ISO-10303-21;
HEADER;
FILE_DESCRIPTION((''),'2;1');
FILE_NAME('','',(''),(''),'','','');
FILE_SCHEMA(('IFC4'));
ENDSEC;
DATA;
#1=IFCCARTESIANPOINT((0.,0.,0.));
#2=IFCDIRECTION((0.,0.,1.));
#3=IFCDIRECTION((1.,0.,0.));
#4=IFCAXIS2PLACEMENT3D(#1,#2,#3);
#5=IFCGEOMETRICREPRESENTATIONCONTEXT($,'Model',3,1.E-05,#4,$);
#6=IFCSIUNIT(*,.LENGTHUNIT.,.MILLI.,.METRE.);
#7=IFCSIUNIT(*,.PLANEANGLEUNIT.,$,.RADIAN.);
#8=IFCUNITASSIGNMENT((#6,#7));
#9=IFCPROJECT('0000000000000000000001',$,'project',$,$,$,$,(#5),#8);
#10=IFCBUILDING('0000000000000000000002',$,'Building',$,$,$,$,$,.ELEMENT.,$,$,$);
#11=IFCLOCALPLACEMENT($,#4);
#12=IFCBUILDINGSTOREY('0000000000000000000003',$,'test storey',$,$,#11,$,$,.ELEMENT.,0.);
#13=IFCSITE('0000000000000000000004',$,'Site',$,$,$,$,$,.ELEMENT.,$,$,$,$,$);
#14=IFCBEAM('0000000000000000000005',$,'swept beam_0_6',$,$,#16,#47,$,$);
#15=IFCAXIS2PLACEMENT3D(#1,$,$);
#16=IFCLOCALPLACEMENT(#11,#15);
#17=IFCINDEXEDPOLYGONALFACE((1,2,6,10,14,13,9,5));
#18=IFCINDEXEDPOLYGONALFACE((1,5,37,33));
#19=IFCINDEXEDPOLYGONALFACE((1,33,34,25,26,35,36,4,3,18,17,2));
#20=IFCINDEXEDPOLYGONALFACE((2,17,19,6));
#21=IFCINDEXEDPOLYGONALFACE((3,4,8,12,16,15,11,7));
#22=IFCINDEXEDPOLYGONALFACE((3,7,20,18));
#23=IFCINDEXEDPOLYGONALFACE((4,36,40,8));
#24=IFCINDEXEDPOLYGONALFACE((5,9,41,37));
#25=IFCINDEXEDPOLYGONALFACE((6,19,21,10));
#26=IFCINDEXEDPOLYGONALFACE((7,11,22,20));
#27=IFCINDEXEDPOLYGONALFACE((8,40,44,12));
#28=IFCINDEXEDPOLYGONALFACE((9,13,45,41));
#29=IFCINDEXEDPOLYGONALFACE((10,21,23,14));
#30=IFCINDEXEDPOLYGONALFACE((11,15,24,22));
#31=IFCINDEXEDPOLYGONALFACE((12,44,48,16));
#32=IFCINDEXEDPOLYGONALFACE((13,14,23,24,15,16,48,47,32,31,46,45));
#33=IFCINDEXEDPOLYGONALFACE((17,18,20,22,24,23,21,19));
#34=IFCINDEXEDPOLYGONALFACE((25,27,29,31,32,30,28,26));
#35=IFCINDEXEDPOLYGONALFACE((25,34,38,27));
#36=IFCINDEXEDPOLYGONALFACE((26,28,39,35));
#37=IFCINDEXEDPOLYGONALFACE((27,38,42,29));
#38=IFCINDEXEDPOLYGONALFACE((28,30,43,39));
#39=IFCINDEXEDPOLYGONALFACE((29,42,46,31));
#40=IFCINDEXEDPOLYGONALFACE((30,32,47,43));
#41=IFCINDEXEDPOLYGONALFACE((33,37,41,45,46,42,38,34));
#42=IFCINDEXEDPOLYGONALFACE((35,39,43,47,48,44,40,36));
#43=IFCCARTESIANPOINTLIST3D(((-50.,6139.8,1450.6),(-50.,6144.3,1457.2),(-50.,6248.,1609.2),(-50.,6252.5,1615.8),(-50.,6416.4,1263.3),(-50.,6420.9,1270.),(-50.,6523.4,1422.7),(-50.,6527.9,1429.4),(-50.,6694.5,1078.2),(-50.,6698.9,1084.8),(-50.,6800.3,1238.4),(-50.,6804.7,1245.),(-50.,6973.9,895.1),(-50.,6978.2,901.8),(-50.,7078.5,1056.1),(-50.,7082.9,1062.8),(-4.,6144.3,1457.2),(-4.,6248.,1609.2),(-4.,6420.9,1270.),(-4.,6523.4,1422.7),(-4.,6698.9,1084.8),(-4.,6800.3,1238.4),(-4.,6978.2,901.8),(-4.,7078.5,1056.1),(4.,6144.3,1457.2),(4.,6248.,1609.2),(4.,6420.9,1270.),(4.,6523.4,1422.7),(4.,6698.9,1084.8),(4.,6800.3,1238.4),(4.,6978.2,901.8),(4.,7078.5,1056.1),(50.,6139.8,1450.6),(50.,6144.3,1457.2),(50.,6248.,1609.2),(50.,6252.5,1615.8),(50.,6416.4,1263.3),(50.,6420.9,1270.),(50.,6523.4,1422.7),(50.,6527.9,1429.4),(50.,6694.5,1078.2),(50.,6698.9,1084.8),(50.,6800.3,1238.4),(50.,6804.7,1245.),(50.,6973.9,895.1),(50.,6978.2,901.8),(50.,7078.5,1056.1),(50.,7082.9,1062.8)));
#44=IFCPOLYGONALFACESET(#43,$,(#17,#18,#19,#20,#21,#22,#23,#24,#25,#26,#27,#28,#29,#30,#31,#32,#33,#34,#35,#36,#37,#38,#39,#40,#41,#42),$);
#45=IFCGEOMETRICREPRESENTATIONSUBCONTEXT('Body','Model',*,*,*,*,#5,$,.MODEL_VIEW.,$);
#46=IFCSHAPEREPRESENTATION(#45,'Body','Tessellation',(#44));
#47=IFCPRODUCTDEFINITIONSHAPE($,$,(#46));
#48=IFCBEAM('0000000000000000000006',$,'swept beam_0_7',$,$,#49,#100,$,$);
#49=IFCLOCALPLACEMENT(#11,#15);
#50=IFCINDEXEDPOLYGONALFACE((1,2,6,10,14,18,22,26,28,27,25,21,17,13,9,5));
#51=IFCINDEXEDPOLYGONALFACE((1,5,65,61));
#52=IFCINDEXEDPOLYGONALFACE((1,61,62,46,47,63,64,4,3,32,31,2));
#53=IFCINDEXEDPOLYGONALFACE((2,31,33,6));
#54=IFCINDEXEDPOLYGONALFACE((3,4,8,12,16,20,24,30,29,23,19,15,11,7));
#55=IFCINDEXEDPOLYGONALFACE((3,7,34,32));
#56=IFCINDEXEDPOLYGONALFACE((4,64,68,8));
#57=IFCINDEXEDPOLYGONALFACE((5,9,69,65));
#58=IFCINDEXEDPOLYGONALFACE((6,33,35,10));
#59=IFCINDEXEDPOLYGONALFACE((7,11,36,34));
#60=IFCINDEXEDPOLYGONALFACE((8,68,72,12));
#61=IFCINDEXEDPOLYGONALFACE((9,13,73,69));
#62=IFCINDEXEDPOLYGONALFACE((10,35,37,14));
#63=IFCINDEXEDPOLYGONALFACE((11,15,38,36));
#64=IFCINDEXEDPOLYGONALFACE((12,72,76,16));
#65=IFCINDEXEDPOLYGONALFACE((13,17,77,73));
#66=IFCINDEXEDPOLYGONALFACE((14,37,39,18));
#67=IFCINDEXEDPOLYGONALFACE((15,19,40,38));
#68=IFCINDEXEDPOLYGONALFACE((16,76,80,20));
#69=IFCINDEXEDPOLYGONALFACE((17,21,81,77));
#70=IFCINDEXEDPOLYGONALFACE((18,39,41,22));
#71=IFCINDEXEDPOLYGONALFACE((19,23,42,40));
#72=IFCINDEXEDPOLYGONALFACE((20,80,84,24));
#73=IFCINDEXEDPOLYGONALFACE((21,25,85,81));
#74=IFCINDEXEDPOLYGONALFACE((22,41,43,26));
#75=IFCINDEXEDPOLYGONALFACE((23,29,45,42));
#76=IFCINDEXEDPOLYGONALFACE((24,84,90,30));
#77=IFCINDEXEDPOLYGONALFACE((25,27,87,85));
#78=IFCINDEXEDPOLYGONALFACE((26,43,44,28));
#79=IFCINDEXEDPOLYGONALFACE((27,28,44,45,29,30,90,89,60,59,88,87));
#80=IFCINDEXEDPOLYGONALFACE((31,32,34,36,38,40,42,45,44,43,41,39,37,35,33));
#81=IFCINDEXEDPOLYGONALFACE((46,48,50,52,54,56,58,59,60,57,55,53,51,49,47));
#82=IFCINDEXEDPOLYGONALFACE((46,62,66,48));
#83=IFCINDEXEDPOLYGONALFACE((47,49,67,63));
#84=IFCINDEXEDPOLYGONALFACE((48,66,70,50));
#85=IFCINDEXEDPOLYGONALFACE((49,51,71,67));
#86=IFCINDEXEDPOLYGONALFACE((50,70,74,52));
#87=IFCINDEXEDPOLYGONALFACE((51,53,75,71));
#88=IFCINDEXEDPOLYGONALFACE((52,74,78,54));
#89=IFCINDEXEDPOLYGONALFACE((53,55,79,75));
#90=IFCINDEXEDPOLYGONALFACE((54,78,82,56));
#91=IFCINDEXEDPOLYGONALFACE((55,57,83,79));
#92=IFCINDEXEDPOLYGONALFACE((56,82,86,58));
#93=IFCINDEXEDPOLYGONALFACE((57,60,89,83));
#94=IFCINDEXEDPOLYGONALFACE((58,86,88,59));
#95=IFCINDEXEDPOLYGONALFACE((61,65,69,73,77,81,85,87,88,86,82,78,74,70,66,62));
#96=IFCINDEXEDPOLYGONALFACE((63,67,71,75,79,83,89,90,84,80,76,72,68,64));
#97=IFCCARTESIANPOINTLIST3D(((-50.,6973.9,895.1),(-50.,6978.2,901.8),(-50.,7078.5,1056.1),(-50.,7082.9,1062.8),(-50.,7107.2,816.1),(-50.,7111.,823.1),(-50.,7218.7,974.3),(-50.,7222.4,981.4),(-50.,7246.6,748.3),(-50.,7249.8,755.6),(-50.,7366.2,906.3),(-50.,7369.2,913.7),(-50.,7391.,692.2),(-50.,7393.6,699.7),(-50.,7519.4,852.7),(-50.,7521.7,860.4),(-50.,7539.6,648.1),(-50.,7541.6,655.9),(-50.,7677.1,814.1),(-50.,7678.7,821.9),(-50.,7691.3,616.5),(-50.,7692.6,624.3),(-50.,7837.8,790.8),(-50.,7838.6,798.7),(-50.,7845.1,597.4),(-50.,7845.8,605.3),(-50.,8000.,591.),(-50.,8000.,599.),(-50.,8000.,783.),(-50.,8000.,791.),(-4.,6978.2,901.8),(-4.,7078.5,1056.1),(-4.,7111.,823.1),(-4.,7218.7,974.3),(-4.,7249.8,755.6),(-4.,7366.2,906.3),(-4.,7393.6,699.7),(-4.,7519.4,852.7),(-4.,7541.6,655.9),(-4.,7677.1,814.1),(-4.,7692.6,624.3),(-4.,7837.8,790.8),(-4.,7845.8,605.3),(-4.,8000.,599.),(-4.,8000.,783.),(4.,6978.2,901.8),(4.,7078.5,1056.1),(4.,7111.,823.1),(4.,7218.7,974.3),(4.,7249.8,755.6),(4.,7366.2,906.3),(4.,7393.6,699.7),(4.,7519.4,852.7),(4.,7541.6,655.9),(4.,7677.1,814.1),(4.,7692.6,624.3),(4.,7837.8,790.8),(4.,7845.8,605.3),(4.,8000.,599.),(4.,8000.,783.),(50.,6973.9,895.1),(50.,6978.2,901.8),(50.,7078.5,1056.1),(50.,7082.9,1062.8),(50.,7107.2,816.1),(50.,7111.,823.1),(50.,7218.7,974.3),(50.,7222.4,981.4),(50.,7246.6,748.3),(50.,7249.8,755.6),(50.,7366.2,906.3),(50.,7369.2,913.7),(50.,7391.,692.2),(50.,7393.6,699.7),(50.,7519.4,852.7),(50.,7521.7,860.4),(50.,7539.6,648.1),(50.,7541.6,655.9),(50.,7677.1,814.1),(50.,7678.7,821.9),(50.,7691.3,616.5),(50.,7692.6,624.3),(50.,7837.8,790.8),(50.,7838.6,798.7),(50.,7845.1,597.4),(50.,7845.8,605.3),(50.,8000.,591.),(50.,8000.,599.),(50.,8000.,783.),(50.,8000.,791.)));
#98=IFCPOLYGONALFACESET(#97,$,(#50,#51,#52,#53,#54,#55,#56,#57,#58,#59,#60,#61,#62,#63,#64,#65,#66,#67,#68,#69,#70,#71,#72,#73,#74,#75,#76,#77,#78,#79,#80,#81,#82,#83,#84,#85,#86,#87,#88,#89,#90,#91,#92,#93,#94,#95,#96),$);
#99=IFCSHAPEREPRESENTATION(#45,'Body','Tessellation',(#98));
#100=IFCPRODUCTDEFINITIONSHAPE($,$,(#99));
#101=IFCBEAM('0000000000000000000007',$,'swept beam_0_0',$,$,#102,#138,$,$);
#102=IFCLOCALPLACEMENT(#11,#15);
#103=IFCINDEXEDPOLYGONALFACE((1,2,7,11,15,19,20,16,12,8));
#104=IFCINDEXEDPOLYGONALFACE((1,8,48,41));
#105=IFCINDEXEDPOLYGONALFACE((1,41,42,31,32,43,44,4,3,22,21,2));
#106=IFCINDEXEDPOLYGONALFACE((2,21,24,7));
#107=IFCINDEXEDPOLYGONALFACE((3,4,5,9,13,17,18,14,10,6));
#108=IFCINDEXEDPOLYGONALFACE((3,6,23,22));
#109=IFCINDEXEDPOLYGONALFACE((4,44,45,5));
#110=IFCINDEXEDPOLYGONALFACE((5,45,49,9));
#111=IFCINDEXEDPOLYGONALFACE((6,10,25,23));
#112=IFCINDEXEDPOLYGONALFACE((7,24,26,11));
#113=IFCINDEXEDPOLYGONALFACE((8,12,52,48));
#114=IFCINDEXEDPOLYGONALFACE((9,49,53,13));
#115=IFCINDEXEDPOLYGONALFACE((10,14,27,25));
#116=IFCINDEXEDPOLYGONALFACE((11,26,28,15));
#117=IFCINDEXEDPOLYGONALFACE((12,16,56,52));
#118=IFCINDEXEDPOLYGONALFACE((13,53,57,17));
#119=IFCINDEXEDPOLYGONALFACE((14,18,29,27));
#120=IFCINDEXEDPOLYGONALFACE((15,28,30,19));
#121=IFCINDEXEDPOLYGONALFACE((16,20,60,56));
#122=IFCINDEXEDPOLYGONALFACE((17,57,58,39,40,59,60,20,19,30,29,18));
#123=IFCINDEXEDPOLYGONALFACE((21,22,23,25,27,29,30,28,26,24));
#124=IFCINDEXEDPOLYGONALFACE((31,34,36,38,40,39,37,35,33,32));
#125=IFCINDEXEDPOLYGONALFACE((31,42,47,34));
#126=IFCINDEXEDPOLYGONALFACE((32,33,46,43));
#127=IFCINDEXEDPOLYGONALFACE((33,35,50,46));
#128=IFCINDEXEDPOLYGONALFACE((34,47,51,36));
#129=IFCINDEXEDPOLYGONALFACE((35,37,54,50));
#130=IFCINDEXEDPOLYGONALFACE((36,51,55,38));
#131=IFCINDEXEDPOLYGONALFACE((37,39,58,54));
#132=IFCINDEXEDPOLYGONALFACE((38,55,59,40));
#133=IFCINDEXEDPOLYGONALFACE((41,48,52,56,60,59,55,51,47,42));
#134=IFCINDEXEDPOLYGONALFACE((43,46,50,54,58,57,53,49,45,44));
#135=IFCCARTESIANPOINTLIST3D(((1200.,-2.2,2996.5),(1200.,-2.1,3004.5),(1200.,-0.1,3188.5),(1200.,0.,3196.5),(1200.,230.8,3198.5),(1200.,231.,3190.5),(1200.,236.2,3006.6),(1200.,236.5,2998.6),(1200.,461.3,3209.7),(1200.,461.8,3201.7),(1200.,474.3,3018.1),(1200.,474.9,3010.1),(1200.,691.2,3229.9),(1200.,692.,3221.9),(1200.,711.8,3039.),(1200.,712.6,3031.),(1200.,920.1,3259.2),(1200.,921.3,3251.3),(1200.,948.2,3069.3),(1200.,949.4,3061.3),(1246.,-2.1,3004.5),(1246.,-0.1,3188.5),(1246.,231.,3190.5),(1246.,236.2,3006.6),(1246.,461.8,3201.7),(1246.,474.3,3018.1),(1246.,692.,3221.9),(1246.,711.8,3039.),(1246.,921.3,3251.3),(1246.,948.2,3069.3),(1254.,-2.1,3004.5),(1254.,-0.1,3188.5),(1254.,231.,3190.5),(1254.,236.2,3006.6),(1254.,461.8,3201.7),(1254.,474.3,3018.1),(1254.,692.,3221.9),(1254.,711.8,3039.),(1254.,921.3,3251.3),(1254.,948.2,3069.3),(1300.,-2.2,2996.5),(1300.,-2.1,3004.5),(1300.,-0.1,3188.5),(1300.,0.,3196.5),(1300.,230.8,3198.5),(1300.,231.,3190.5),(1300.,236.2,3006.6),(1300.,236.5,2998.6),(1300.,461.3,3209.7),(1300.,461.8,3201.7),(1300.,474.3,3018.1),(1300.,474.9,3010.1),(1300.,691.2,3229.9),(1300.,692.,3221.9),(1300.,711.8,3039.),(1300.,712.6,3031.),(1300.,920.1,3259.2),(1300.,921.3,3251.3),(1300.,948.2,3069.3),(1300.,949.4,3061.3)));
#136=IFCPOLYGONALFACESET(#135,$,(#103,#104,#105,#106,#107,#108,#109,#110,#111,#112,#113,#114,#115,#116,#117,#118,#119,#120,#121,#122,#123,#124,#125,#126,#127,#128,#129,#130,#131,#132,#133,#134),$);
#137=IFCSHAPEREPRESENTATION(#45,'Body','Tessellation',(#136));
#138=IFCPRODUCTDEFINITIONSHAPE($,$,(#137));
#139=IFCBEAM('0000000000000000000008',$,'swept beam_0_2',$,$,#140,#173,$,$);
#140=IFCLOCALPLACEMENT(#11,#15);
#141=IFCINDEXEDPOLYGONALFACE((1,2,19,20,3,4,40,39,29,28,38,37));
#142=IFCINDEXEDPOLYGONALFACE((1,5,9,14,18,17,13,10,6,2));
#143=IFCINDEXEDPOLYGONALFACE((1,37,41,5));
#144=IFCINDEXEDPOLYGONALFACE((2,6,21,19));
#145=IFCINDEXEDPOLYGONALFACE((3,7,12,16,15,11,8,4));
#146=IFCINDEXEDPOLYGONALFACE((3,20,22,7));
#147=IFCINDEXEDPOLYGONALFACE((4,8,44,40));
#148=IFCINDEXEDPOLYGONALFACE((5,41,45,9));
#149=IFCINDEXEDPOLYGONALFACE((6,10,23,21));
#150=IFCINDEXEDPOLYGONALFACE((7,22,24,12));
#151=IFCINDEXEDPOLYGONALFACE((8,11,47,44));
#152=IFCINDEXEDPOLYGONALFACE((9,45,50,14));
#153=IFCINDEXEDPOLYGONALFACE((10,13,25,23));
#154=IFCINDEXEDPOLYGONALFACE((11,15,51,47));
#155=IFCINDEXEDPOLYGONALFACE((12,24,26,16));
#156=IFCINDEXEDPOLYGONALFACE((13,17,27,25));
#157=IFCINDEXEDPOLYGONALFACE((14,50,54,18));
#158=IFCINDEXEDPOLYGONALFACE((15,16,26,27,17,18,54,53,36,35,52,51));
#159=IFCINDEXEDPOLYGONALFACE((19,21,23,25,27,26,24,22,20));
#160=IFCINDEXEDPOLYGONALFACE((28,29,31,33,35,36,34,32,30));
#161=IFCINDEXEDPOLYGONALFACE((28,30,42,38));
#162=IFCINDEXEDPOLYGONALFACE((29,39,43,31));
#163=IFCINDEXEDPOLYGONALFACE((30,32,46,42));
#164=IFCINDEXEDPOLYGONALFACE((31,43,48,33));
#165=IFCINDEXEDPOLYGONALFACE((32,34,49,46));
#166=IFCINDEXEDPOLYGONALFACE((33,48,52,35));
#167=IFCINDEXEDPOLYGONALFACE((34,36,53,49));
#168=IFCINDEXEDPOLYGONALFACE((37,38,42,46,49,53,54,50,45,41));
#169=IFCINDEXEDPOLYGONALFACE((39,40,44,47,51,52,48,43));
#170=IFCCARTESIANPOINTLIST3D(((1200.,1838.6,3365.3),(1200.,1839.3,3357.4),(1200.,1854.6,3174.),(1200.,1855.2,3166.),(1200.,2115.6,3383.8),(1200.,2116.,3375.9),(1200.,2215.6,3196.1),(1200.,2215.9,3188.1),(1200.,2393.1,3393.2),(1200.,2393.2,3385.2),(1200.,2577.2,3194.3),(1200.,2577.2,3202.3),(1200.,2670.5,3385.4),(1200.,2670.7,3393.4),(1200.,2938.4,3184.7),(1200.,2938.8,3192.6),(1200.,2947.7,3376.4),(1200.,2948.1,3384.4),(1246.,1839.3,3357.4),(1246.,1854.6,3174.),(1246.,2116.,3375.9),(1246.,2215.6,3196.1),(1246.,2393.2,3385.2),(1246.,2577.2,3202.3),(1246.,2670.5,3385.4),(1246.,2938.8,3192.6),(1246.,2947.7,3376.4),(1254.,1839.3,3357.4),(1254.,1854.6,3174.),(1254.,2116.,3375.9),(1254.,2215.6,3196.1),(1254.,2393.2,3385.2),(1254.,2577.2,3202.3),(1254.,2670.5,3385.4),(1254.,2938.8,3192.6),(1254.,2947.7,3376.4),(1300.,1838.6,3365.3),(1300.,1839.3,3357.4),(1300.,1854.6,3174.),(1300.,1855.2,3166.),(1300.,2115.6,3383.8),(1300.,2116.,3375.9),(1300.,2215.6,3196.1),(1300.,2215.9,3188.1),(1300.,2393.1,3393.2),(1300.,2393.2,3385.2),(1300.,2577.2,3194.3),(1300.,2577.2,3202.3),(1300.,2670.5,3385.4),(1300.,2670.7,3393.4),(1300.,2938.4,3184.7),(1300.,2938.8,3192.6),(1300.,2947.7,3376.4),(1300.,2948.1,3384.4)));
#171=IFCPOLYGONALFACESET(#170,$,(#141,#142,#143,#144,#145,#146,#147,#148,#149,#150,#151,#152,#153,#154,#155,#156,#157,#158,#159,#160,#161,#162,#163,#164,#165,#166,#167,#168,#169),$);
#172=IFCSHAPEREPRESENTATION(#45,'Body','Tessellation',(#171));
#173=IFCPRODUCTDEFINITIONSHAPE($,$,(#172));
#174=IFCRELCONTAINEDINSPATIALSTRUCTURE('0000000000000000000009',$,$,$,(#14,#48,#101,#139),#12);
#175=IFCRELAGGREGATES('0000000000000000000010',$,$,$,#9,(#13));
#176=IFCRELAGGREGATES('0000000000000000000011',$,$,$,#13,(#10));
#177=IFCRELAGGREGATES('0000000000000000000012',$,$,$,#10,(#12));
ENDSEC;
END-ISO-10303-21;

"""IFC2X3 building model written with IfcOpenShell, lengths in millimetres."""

from ifc_helpers import new_model, entity, si_unit, origin_with_axes, place, context, subcontext, project, spatial, element, save


model = new_model("IFC2X3")

# Units and contexts
model_context = context("Model", 3, precision=1e-05, world=origin_with_axes())
body_context = subcontext(model_context, "Body", "Model", "MODEL_VIEW")
ifc_project = project(units=[si_unit("LENGTHUNIT", "METRE", prefix="MILLI"), si_unit("PLANEANGLEUNIT", "RADIAN")], contexts=[model_context])

# Site, building, storey
site = spatial("IfcSite", under=ifc_project, Name="Site", CompositionType="ELEMENT")
building = spatial("IfcBuilding", under=site, Name="Building", CompositionType="ELEMENT")
storey_placement = place(None, origin_with_axes())
storey = spatial("IfcBuildingStorey", under=building, at=storey_placement, Name="test storey", CompositionType="ELEMENT", Elevation=0.0)

# Beams
beam_1_placement = place(storey_placement, origin_with_axes())
element("IfcBeam", 1, at=beam_1_placement, inside=storey, Name="swept beam_0_6", context=body_context, shape_type="SweptSolid", body=[
    entity("IfcRevolvedAreaSolid", entity("IfcArbitraryClosedProfileDef", "AREA", None, entity("IfcPolyline", [entity("IfcCartesianPoint", [192.0, 50.0]), entity("IfcCartesianPoint", [192.0, 4.0]), entity("IfcCartesianPoint", [8.0, 4.0]), entity("IfcCartesianPoint", [8.0, 50.0]), entity("IfcCartesianPoint", [0.0, 50.0]), entity("IfcCartesianPoint", [0.0, -50.0]), entity("IfcCartesianPoint", [8.0, -50.0]), entity("IfcCartesianPoint", [8.0, -4.0]), entity("IfcCartesianPoint", [192.0, -4.0]), entity("IfcCartesianPoint", [192.0, -50.0]), entity("IfcCartesianPoint", [200.0, -50.0]), entity("IfcCartesianPoint", [200.0, 50.0]), entity("IfcCartesianPoint", [192.0, 50.0])])), entity("IfcAxis2Placement3D", entity("IfcCartesianPoint", [0.0, 6252.5, 1615.8]), entity("IfcDirection", [0.0, -0.826, 0.5636]), entity("IfcDirection", [0.0, -0.5636, -0.826])), entity("IfcAxis1Placement", entity("IfcCartesianPoint", [-44340.2, 0.0, 0.0]), entity("IfcDirection", [0.0, 1.0, 0.0])), 0.0225),
])
beam_2_placement = place(storey_placement, origin_with_axes())
element("IfcBeam", 2, at=beam_2_placement, inside=storey, Name="swept beam_0_7", context=body_context, shape_type="SweptSolid", body=[
    entity("IfcRevolvedAreaSolid", entity("IfcArbitraryClosedProfileDef", "AREA", None, entity("IfcPolyline", [entity("IfcCartesianPoint", [192.0, 50.0]), entity("IfcCartesianPoint", [192.0, 4.0]), entity("IfcCartesianPoint", [8.0, 4.0]), entity("IfcCartesianPoint", [8.0, 50.0]), entity("IfcCartesianPoint", [0.0, 50.0]), entity("IfcCartesianPoint", [0.0, -50.0]), entity("IfcCartesianPoint", [8.0, -50.0]), entity("IfcCartesianPoint", [8.0, -4.0]), entity("IfcCartesianPoint", [192.0, -4.0]), entity("IfcCartesianPoint", [192.0, -50.0]), entity("IfcCartesianPoint", [200.0, -50.0]), entity("IfcCartesianPoint", [200.0, 50.0]), entity("IfcCartesianPoint", [192.0, 50.0])])), entity("IfcAxis2Placement3D", entity("IfcCartesianPoint", [0.0, 7082.9, 1062.8]), entity("IfcDirection", [0.0, -0.8385, 0.5449]), entity("IfcDirection", [0.0, -0.5449, -0.8385])), entity("IfcAxis1Placement", entity("IfcCartesianPoint", [-1683.2, 0.0, 0.0]), entity("IfcDirection", [0.0, 1.0, 0.0])), 0.576247),
])
beam_3_placement = place(storey_placement, origin_with_axes())
element("IfcBeam", 3, at=beam_3_placement, inside=storey, Name="swept beam_0_0", context=body_context, shape_type="SweptSolid", body=[
    entity("IfcRevolvedAreaSolid", entity("IfcArbitraryClosedProfileDef", "AREA", None, entity("IfcPolyline", [entity("IfcCartesianPoint", [192.0, 50.0]), entity("IfcCartesianPoint", [192.0, 4.0]), entity("IfcCartesianPoint", [8.0, 4.0]), entity("IfcCartesianPoint", [8.0, 50.0]), entity("IfcCartesianPoint", [0.0, 50.0]), entity("IfcCartesianPoint", [0.0, -50.0]), entity("IfcCartesianPoint", [8.0, -50.0]), entity("IfcCartesianPoint", [8.0, -4.0]), entity("IfcCartesianPoint", [192.0, -4.0]), entity("IfcCartesianPoint", [192.0, -50.0]), entity("IfcCartesianPoint", [200.0, -50.0]), entity("IfcCartesianPoint", [200.0, 50.0]), entity("IfcCartesianPoint", [192.0, 50.0])])), entity("IfcAxis2Placement3D", entity("IfcCartesianPoint", [1250.0, 0.0, 3196.5]), entity("IfcDirection", [0.0, -0.9999, 0.011]), entity("IfcDirection", [0.0, -0.011, -0.9999])), entity("IfcAxis1Placement", entity("IfcCartesianPoint", [-5840.2, 0.0, 0.0]), entity("IfcDirection", [0.0, 1.0, 0.0])), 0.158075),
])
beam_4_placement = place(storey_placement, origin_with_axes())
element("IfcBeam", 4, at=beam_4_placement, inside=storey, Name="swept beam_0_2", context=body_context, shape_type="SweptSolid", body=[
    entity("IfcRevolvedAreaSolid", entity("IfcArbitraryClosedProfileDef", "AREA", None, entity("IfcPolyline", [entity("IfcCartesianPoint", [-192.0, -50.0]), entity("IfcCartesianPoint", [-192.0, -4.0]), entity("IfcCartesianPoint", [-8.0, -4.0]), entity("IfcCartesianPoint", [-8.0, -50.0]), entity("IfcCartesianPoint", [0.0, -50.0]), entity("IfcCartesianPoint", [0.0, 50.0]), entity("IfcCartesianPoint", [-8.0, 50.0]), entity("IfcCartesianPoint", [-8.0, 4.0]), entity("IfcCartesianPoint", [-192.0, 4.0]), entity("IfcCartesianPoint", [-192.0, 50.0]), entity("IfcCartesianPoint", [-200.0, 50.0]), entity("IfcCartesianPoint", [-200.0, -50.0]), entity("IfcCartesianPoint", [-192.0, -50.0])])), entity("IfcAxis2Placement3D", entity("IfcCartesianPoint", [1250.0, 1838.6, 3365.3]), entity("IfcDirection", [0.0, -0.9965, -0.0831]), entity("IfcDirection", [0.0, -0.0831, 0.9965])), entity("IfcAxis1Placement", entity("IfcCartesianPoint", [-8410.7, 0.0, 0.0]), entity("IfcDirection", [0.0, 1.0, 0.0])), 0.132032),
])

save(model, "model.ifc")
